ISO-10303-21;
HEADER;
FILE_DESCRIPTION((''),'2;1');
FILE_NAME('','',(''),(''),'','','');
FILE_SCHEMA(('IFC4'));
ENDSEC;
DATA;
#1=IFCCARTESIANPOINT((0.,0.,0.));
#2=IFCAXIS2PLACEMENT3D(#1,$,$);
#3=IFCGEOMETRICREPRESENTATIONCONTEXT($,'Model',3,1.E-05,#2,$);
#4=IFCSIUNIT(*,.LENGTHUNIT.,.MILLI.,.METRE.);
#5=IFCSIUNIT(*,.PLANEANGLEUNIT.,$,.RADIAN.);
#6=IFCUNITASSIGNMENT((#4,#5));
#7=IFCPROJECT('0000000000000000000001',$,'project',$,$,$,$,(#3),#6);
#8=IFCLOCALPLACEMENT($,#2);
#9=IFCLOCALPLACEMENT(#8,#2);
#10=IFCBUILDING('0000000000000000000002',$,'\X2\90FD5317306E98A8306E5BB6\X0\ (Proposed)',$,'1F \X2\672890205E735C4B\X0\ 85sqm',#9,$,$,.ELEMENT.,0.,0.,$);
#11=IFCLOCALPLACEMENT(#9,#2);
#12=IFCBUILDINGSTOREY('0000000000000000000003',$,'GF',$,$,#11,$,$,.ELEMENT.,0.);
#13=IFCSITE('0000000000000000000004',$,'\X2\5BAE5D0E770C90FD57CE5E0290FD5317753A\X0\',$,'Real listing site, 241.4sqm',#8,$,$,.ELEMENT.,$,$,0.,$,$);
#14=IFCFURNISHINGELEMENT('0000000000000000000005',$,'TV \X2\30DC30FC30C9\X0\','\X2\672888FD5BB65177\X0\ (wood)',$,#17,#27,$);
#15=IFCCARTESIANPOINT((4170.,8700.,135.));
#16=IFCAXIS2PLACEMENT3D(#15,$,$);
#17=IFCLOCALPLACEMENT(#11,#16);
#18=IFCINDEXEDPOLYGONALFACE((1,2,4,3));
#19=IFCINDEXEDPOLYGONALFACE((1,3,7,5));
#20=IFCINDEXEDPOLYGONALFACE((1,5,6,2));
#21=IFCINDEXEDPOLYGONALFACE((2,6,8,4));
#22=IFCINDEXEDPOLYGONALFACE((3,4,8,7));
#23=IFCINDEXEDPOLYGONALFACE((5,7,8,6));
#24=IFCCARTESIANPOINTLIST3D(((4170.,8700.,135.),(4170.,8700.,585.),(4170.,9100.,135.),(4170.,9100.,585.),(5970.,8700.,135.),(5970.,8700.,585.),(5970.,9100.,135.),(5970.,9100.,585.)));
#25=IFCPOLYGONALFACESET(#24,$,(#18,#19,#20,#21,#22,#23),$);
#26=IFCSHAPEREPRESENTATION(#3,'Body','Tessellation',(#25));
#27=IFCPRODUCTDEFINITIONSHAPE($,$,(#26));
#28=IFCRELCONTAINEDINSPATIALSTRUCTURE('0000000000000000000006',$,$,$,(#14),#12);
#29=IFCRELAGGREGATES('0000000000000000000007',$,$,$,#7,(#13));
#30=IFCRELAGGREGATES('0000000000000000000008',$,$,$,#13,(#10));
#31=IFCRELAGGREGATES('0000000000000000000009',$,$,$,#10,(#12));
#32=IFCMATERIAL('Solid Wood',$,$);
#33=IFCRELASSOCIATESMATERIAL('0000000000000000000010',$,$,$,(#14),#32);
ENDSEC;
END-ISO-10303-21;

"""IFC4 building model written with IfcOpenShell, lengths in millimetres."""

from ifc_helpers import new_model, si_unit, frame, frame_2d, origin, place, context, project, spatial, rectangle, extrude, material, element, save


model = new_model("IFC4")

# Units and contexts
model_context = context("Model", 3, precision=1e-05, world=origin())
ifc_project = project(units=[si_unit("LENGTHUNIT", "METRE", prefix="MILLI"), si_unit("PLANEANGLEUNIT", "RADIAN")], contexts=[model_context])

# Site, building, storey
site_placement = place(None, origin())
site = spatial("IfcSite", under=ifc_project, at=site_placement, Name="宮崎県都城市都北町", ObjectType="Real listing site, 241.4sqm", CompositionType="ELEMENT", RefElevation=0.0)
building_placement = place(site_placement, origin())
building = spatial("IfcBuilding", under=site, at=building_placement, Name="都北の風の家 (Proposed)", ObjectType="1F 木造平屋 85sqm", CompositionType="ELEMENT", ElevationOfRefHeight=0.0, ElevationOfTerrain=0.0)
storey_placement = place(building_placement, origin())
storey = spatial("IfcBuildingStorey", under=building, at=storey_placement, Name="GF", CompositionType="ELEMENT", Elevation=0.0)

# Shared definitions
ifc_material_1 = material(Name="Solid Wood")

# Furnishing element
furnishing_1_placement = place(storey_placement, frame((4170.0, 8700.0, 135.0)))
element("IfcFurnishingElement", 1, at=furnishing_1_placement, inside=storey, material=ifc_material_1, Name="TV ボード", Description="木製家具 (wood)", context=model_context, shape_type="SweptSolid", body=[
    extrude(rectangle(XDim=1800.0, YDim=400.0, at=frame_2d((900.0, 200.0))), frame((4170.0, 8700.0, 135.0)), (0.0, 0.0, 1.0), 450.0),
])

save(model, "model.ifc")
